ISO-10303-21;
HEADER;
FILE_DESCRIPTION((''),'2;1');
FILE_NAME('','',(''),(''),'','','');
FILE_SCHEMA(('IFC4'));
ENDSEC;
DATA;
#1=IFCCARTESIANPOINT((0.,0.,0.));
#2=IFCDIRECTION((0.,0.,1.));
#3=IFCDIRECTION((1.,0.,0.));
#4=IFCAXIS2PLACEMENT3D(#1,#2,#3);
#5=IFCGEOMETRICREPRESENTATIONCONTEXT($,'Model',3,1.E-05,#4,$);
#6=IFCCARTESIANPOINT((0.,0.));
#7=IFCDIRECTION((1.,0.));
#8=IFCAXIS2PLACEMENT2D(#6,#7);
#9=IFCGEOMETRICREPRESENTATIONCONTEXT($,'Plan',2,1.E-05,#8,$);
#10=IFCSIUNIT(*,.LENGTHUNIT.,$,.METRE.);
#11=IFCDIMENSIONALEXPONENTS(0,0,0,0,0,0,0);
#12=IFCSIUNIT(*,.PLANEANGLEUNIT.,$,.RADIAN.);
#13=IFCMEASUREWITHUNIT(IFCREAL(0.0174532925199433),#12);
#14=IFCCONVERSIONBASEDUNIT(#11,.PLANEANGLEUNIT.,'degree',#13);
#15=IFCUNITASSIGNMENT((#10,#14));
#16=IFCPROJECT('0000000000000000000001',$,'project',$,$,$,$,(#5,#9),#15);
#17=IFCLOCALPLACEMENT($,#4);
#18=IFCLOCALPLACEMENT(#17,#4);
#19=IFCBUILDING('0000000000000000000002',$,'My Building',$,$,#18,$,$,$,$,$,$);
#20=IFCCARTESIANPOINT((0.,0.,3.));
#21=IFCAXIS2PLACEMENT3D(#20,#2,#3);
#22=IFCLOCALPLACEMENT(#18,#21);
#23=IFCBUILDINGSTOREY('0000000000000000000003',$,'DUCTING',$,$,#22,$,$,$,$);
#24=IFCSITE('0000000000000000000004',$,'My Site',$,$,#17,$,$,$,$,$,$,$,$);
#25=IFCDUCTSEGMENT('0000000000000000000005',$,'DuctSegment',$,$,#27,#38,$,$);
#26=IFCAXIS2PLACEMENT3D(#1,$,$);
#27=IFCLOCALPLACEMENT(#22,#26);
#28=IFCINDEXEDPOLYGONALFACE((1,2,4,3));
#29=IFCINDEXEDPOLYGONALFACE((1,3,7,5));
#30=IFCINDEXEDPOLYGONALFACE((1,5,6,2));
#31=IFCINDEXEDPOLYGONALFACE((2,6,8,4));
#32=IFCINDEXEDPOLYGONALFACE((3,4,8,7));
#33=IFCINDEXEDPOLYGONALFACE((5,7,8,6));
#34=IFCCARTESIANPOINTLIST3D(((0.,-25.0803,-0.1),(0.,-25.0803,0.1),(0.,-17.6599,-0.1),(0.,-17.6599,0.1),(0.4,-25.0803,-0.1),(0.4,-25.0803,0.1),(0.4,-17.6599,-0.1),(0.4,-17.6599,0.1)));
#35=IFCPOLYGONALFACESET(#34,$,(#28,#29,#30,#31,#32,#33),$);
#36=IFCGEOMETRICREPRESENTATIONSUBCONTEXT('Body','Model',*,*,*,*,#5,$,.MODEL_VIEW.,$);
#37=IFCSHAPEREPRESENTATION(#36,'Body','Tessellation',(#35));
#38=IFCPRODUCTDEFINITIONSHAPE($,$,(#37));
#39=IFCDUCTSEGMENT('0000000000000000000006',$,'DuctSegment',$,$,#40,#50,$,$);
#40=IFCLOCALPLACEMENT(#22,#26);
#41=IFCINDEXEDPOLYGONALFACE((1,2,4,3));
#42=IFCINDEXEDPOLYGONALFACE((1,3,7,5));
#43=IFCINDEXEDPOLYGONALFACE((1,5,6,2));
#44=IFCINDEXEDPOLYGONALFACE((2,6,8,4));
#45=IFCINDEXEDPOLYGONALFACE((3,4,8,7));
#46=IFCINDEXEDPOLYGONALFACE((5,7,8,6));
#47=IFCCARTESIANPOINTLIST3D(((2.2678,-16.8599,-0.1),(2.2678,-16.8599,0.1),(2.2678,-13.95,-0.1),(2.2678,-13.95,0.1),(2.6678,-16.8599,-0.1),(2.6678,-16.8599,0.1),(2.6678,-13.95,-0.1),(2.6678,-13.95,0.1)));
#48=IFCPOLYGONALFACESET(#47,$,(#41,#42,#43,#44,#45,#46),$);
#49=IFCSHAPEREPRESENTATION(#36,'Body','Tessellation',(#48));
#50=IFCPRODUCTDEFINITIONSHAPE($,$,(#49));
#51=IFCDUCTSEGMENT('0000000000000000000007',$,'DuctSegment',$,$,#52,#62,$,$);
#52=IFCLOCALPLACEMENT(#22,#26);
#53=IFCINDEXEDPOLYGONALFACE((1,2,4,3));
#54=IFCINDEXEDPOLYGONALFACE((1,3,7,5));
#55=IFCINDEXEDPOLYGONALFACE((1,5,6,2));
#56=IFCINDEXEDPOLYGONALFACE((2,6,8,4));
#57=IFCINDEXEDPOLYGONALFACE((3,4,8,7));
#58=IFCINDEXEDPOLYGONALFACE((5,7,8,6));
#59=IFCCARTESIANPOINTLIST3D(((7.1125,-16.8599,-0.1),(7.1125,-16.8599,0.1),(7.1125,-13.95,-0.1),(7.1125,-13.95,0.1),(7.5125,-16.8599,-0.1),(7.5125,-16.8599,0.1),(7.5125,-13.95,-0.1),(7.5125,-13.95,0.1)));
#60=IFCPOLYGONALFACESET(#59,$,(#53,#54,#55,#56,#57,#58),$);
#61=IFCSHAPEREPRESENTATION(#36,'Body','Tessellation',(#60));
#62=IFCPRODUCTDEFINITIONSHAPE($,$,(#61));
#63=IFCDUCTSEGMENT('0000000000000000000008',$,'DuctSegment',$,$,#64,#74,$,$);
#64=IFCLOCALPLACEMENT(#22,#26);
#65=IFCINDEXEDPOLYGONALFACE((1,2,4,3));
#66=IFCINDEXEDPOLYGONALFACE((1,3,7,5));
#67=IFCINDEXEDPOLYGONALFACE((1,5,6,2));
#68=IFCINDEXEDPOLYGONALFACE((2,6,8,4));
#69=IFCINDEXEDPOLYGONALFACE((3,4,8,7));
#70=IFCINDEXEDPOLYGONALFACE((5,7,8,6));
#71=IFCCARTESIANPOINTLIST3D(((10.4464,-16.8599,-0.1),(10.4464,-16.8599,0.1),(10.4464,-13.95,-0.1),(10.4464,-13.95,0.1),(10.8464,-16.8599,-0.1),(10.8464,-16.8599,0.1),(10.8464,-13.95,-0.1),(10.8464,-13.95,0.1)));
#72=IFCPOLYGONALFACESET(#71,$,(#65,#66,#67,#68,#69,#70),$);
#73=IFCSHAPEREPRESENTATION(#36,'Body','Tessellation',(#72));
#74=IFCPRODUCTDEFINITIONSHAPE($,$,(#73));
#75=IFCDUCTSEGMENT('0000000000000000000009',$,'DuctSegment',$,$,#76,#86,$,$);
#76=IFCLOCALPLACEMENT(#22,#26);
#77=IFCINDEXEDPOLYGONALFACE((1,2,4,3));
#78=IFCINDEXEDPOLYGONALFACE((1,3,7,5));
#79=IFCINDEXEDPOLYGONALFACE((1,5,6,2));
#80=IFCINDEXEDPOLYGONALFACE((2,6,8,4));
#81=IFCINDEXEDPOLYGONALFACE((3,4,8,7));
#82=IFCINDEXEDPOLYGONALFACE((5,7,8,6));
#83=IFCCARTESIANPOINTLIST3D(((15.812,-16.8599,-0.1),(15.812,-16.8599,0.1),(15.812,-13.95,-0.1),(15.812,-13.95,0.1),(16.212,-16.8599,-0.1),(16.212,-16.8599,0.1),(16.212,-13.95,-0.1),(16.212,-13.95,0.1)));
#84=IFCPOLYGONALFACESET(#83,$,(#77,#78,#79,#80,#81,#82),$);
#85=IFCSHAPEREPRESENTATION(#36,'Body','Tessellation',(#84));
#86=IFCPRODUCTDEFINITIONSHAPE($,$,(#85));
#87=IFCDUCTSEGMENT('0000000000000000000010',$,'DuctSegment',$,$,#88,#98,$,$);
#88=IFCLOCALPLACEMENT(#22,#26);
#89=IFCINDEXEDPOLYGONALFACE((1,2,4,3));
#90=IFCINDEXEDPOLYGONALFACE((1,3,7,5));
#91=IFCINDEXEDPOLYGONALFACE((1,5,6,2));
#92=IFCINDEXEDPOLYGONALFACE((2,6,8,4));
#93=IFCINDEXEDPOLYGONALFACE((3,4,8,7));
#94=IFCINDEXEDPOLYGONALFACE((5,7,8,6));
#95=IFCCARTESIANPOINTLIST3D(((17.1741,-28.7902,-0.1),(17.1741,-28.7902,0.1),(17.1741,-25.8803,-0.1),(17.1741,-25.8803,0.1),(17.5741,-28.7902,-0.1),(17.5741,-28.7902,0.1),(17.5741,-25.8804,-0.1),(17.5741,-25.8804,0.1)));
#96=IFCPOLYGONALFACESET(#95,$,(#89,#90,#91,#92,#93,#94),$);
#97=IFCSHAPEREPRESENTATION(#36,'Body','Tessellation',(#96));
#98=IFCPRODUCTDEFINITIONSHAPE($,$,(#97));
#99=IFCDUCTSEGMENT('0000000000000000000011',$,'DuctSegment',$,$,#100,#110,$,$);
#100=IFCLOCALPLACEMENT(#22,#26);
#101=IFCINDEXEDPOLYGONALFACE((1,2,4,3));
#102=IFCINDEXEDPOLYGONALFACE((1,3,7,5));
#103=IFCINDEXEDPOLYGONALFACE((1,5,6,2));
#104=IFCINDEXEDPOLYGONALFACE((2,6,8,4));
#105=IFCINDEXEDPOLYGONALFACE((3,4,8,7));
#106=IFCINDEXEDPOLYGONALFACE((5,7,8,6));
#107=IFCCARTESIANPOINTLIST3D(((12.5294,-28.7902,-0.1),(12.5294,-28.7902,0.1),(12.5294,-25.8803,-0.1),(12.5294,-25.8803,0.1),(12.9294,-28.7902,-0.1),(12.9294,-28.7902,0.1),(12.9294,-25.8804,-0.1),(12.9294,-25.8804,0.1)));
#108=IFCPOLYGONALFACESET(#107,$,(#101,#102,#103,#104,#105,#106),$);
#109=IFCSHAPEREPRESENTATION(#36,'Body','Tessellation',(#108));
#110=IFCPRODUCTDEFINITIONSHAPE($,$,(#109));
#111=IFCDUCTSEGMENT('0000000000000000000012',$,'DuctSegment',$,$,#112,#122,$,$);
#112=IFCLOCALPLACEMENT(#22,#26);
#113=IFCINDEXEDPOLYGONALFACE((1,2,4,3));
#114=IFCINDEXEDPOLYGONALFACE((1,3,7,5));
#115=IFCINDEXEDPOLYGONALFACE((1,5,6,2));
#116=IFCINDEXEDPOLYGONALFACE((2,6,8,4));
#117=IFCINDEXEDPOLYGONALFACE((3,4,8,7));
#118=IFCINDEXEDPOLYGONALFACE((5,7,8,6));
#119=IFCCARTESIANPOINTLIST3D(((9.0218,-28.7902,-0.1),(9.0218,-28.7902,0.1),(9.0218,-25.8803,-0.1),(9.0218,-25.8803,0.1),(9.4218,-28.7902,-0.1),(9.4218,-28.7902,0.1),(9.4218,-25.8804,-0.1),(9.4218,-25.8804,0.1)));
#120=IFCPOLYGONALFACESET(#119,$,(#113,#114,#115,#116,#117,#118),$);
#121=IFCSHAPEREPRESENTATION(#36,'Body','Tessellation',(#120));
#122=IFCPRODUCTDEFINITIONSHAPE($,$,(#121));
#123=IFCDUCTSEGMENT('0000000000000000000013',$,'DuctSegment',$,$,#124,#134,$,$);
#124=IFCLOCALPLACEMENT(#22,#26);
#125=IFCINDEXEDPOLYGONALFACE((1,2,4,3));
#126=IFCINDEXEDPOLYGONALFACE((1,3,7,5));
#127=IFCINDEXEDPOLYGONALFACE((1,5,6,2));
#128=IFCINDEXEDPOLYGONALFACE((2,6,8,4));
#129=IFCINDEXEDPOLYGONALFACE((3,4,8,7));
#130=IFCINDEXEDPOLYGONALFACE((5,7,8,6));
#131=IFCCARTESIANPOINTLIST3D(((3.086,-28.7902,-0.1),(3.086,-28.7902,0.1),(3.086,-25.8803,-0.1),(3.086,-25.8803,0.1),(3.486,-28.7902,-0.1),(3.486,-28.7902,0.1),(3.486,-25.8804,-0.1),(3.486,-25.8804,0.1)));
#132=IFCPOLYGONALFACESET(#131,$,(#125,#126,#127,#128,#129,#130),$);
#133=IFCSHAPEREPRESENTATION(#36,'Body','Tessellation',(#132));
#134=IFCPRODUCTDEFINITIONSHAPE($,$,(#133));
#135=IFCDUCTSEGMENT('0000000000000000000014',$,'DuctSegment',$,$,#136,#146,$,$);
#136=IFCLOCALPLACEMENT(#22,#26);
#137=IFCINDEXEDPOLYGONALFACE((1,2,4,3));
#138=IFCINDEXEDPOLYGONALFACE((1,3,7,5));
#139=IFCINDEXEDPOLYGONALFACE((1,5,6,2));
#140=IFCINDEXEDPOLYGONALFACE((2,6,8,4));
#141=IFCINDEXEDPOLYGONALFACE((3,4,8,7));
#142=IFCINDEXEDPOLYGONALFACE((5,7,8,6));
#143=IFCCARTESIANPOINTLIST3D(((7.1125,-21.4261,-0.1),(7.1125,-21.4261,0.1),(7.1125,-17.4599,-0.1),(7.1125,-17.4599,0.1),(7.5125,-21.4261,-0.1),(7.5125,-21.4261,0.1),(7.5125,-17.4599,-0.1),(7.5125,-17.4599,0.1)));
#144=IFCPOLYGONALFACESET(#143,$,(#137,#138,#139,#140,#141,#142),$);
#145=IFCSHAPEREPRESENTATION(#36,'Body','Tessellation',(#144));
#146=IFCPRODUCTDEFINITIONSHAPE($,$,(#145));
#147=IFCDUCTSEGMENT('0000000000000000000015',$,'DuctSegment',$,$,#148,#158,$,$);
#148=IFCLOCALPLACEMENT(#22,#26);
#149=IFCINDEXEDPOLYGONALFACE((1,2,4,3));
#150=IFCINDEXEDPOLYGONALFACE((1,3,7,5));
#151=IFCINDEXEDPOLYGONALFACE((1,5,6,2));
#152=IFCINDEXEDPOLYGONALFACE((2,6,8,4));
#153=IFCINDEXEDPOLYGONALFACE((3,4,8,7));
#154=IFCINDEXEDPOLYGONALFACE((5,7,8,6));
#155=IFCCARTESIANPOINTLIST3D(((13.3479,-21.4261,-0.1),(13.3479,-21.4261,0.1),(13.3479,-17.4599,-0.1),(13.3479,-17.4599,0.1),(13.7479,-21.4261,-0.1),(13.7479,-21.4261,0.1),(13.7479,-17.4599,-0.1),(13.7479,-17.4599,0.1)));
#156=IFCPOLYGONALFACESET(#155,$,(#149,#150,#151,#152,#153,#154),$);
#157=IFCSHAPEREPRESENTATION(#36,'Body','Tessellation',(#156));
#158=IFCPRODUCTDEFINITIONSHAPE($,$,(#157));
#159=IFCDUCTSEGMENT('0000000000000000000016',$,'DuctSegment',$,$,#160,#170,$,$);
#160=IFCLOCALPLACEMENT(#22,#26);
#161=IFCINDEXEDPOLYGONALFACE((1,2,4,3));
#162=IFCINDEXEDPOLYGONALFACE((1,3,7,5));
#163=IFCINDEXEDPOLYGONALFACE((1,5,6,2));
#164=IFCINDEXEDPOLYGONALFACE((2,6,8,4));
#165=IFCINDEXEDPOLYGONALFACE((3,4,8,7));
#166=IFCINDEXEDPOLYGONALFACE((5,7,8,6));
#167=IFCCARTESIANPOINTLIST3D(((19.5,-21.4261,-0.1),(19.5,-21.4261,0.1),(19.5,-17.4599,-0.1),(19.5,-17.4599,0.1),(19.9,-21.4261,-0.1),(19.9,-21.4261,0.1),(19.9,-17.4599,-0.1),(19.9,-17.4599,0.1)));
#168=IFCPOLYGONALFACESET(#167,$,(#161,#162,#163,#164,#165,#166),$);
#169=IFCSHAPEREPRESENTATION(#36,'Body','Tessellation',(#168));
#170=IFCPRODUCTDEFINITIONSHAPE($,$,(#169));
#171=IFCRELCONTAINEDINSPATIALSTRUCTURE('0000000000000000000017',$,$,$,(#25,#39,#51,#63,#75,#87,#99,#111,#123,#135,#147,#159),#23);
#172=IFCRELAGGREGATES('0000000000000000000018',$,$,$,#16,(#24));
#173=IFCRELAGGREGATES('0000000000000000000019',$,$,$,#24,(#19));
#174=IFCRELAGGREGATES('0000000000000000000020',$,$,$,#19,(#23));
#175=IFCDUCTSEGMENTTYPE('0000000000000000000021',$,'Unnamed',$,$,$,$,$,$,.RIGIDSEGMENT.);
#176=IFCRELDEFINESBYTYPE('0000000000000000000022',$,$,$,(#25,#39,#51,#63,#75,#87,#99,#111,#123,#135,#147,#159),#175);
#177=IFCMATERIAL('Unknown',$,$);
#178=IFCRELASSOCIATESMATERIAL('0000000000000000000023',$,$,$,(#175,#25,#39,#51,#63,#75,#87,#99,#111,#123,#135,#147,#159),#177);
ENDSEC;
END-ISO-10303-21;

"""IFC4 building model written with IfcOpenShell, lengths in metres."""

from ifc_helpers import new_model, entity, si_unit, converted_unit, frame, origin_with_axes, origin_2d_with_axis, place, context, subcontext, project, spatial, rectangle, extrude, material, material_profile, profile_set, profile_usage, type_object, element, save


model = new_model("IFC4")

# Units and contexts
model_context = context("Model", 3, precision=1e-05, world=origin_with_axes())
plan_context = context("Plan", 2, precision=1e-05, world=origin_2d_with_axis())
body_context = subcontext(model_context, "Body", "Model", "MODEL_VIEW")
ifc_project = project(units=[si_unit("LENGTHUNIT", "METRE"), converted_unit("PLANEANGLEUNIT", "degree", entity("IfcReal", 0.0174532925199433), si_unit("PLANEANGLEUNIT", "RADIAN"), dimensions=[0, 0, 0, 0, 0, 0, 0])], contexts=[model_context, plan_context])

# Site, building, storey
site_placement = place(None, origin_with_axes())
site = spatial("IfcSite", under=ifc_project, at=site_placement, Name="My Site")
building_placement = place(site_placement, origin_with_axes())
building = spatial("IfcBuilding", under=site, at=building_placement, Name="My Building")
storey_placement = place(building_placement, frame((0.0, 0.0, 3.0), z_axis=(0.0, 0.0, 1.0), x_axis=(1.0, 0.0, 0.0)))
storey = spatial("IfcBuildingStorey", under=building, at=storey_placement, Name="DUCTING")

# Duct segments
ifc_material = material(Name="Unknown")
ifc_material_profile_1 = material_profile(ifc_material, rectangle(XDim=0.4, YDim=0.2))
ifc_profile_set_1 = profile_set([ifc_material_profile_1])
ifc_profile_usage_1 = profile_usage(ifc_profile_set_1, cardinal=5)
duct_segment_type = type_object("IfcDuctSegmentType", Name="Unnamed", PredefinedType="RIGIDSEGMENT", material=ifc_profile_set_1)
duct_segment_1_placement = place(storey_placement, frame((0.2, -17.6599, 0.0), z_axis=(0.0, -1.0, 0.0), x_axis=(1.0, 0.0, 0.0)))
element("IfcDuctSegment", 1, at=duct_segment_1_placement, inside=storey, type_object=duct_segment_type, material=ifc_profile_usage_1, Name="DuctSegment", context=body_context, shape_type="SweptSolid", body=[
    extrude(rectangle(XDim=0.4, YDim=0.2), origin_with_axes(), (0.0, 0.0, 1.0), 7.4205),
])
ifc_profile_usage_2 = profile_usage(ifc_profile_set_1, cardinal=5)
duct_segment_2_placement = place(storey_placement, frame((2.4678, -13.95, 0.0), z_axis=(0.0, -1.0, 0.0), x_axis=(1.0, 0.0, 0.0)))
element("IfcDuctSegment", 2, at=duct_segment_2_placement, inside=storey, type_object=duct_segment_type, material=ifc_profile_usage_2, Name="DuctSegment", context=body_context, shape_type="SweptSolid", body=[
    extrude(rectangle(XDim=0.4, YDim=0.2), origin_with_axes(), (0.0, 0.0, 1.0), 2.9099),
])
ifc_profile_usage_3 = profile_usage(ifc_profile_set_1, cardinal=5)
duct_segment_3_placement = place(storey_placement, frame((7.3125, -13.95, 0.0), z_axis=(0.0, -1.0, 0.0), x_axis=(1.0, 0.0, 0.0)))
element("IfcDuctSegment", 3, at=duct_segment_3_placement, inside=storey, type_object=duct_segment_type, material=ifc_profile_usage_3, Name="DuctSegment", context=body_context, shape_type="SweptSolid", body=[
    extrude(rectangle(XDim=0.4, YDim=0.2), origin_with_axes(), (0.0, 0.0, 1.0), 2.9099),
])
ifc_profile_usage_4 = profile_usage(ifc_profile_set_1, cardinal=5)
duct_segment_4_placement = place(storey_placement, frame((10.6464, -13.95, 0.0), z_axis=(0.0, -1.0, 0.0), x_axis=(1.0, 0.0, 0.0)))
element("IfcDuctSegment", 4, at=duct_segment_4_placement, inside=storey, type_object=duct_segment_type, material=ifc_profile_usage_4, Name="DuctSegment", context=body_context, shape_type="SweptSolid", body=[
    extrude(rectangle(XDim=0.4, YDim=0.2), origin_with_axes(), (0.0, 0.0, 1.0), 2.9099),
])
ifc_profile_usage_5 = profile_usage(ifc_profile_set_1, cardinal=5)
duct_segment_5_placement = place(storey_placement, frame((16.012, -13.95, 0.0), z_axis=(0.0, -1.0, 0.0), x_axis=(1.0, 0.0, 0.0)))
element("IfcDuctSegment", 5, at=duct_segment_5_placement, inside=storey, type_object=duct_segment_type, material=ifc_profile_usage_5, Name="DuctSegment", context=body_context, shape_type="SweptSolid", body=[
    extrude(rectangle(XDim=0.4, YDim=0.2), origin_with_axes(), (0.0, 0.0, 1.0), 2.9099),
])
ifc_profile_usage_6 = profile_usage(ifc_profile_set_1, cardinal=5)
duct_segment_6_placement = place(storey_placement, frame((17.3741, -28.7902, 0.0), z_axis=(0.000001, 1.0, 0.0), x_axis=(-1.0, 0.000001, 0.0)))
element("IfcDuctSegment", 6, at=duct_segment_6_placement, inside=storey, type_object=duct_segment_type, material=ifc_profile_usage_6, Name="DuctSegment", context=body_context, shape_type="SweptSolid", body=[
    extrude(rectangle(XDim=0.4, YDim=0.2), origin_with_axes(), (0.0, 0.0, 1.0), 2.9099),
])
ifc_profile_usage_7 = profile_usage(ifc_profile_set_1, cardinal=5)
duct_segment_7_placement = place(storey_placement, frame((12.7294, -28.7902, 0.0), z_axis=(0.000001, 1.0, 0.0), x_axis=(-1.0, 0.000001, 0.0)))
element("IfcDuctSegment", 7, at=duct_segment_7_placement, inside=storey, type_object=duct_segment_type, material=ifc_profile_usage_7, Name="DuctSegment", context=body_context, shape_type="SweptSolid", body=[
    extrude(rectangle(XDim=0.4, YDim=0.2), origin_with_axes(), (0.0, 0.0, 1.0), 2.9099),
])
ifc_profile_usage_8 = profile_usage(ifc_profile_set_1, cardinal=5)
duct_segment_8_placement = place(storey_placement, frame((9.2218, -28.7902, 0.0), z_axis=(0.000001, 1.0, 0.0), x_axis=(-1.0, 0.000001, 0.0)))
element("IfcDuctSegment", 8, at=duct_segment_8_placement, inside=storey, type_object=duct_segment_type, material=ifc_profile_usage_8, Name="DuctSegment", context=body_context, shape_type="SweptSolid", body=[
    extrude(rectangle(XDim=0.4, YDim=0.2), origin_with_axes(), (0.0, 0.0, 1.0), 2.9099),
])
ifc_profile_usage_9 = profile_usage(ifc_profile_set_1, cardinal=5)
duct_segment_9_placement = place(storey_placement, frame((3.286, -28.7902, 0.0), z_axis=(0.000001, 1.0, 0.0), x_axis=(-1.0, 0.000001, 0.0)))
element("IfcDuctSegment", 9, at=duct_segment_9_placement, inside=storey, type_object=duct_segment_type, material=ifc_profile_usage_9, Name="DuctSegment", context=body_context, shape_type="SweptSolid", body=[
    extrude(rectangle(XDim=0.4, YDim=0.2), origin_with_axes(), (0.0, 0.0, 1.0), 2.9099),
])
ifc_profile_usage_10 = profile_usage(ifc_profile_set_1, cardinal=5)
duct_segment_10_placement = place(storey_placement, frame((7.3125, -21.4261, 0.0), z_axis=(0.000001, 1.0, 0.0), x_axis=(-1.0, 0.000001, 0.0)))
element("IfcDuctSegment", 10, at=duct_segment_10_placement, inside=storey, type_object=duct_segment_type, material=ifc_profile_usage_10, Name="DuctSegment", context=body_context, shape_type="SweptSolid", body=[
    extrude(rectangle(XDim=0.4, YDim=0.2), origin_with_axes(), (0.0, 0.0, 1.0), 3.9662),
])
ifc_profile_usage_11 = profile_usage(ifc_profile_set_1, cardinal=5)
duct_segment_11_placement = place(storey_placement, frame((13.5479, -21.4261, 0.0), z_axis=(0.000001, 1.0, 0.0), x_axis=(-1.0, 0.000001, 0.0)))
element("IfcDuctSegment", 11, at=duct_segment_11_placement, inside=storey, type_object=duct_segment_type, material=ifc_profile_usage_11, Name="DuctSegment", context=body_context, shape_type="SweptSolid", body=[
    extrude(rectangle(XDim=0.4, YDim=0.2), origin_with_axes(), (0.0, 0.0, 1.0), 3.9662),
])
ifc_profile_usage_12 = profile_usage(ifc_profile_set_1, cardinal=5)
duct_segment_12_placement = place(storey_placement, frame((19.7, -21.4261, 0.0), z_axis=(0.000001, 1.0, 0.0), x_axis=(-1.0, 0.000001, 0.0)))
element("IfcDuctSegment", 12, at=duct_segment_12_placement, inside=storey, type_object=duct_segment_type, material=ifc_profile_usage_12, Name="DuctSegment", context=body_context, shape_type="SweptSolid", body=[
    extrude(rectangle(XDim=0.4, YDim=0.2), origin_with_axes(), (0.0, 0.0, 1.0), 3.9662),
])

save(model, "model.ifc")
